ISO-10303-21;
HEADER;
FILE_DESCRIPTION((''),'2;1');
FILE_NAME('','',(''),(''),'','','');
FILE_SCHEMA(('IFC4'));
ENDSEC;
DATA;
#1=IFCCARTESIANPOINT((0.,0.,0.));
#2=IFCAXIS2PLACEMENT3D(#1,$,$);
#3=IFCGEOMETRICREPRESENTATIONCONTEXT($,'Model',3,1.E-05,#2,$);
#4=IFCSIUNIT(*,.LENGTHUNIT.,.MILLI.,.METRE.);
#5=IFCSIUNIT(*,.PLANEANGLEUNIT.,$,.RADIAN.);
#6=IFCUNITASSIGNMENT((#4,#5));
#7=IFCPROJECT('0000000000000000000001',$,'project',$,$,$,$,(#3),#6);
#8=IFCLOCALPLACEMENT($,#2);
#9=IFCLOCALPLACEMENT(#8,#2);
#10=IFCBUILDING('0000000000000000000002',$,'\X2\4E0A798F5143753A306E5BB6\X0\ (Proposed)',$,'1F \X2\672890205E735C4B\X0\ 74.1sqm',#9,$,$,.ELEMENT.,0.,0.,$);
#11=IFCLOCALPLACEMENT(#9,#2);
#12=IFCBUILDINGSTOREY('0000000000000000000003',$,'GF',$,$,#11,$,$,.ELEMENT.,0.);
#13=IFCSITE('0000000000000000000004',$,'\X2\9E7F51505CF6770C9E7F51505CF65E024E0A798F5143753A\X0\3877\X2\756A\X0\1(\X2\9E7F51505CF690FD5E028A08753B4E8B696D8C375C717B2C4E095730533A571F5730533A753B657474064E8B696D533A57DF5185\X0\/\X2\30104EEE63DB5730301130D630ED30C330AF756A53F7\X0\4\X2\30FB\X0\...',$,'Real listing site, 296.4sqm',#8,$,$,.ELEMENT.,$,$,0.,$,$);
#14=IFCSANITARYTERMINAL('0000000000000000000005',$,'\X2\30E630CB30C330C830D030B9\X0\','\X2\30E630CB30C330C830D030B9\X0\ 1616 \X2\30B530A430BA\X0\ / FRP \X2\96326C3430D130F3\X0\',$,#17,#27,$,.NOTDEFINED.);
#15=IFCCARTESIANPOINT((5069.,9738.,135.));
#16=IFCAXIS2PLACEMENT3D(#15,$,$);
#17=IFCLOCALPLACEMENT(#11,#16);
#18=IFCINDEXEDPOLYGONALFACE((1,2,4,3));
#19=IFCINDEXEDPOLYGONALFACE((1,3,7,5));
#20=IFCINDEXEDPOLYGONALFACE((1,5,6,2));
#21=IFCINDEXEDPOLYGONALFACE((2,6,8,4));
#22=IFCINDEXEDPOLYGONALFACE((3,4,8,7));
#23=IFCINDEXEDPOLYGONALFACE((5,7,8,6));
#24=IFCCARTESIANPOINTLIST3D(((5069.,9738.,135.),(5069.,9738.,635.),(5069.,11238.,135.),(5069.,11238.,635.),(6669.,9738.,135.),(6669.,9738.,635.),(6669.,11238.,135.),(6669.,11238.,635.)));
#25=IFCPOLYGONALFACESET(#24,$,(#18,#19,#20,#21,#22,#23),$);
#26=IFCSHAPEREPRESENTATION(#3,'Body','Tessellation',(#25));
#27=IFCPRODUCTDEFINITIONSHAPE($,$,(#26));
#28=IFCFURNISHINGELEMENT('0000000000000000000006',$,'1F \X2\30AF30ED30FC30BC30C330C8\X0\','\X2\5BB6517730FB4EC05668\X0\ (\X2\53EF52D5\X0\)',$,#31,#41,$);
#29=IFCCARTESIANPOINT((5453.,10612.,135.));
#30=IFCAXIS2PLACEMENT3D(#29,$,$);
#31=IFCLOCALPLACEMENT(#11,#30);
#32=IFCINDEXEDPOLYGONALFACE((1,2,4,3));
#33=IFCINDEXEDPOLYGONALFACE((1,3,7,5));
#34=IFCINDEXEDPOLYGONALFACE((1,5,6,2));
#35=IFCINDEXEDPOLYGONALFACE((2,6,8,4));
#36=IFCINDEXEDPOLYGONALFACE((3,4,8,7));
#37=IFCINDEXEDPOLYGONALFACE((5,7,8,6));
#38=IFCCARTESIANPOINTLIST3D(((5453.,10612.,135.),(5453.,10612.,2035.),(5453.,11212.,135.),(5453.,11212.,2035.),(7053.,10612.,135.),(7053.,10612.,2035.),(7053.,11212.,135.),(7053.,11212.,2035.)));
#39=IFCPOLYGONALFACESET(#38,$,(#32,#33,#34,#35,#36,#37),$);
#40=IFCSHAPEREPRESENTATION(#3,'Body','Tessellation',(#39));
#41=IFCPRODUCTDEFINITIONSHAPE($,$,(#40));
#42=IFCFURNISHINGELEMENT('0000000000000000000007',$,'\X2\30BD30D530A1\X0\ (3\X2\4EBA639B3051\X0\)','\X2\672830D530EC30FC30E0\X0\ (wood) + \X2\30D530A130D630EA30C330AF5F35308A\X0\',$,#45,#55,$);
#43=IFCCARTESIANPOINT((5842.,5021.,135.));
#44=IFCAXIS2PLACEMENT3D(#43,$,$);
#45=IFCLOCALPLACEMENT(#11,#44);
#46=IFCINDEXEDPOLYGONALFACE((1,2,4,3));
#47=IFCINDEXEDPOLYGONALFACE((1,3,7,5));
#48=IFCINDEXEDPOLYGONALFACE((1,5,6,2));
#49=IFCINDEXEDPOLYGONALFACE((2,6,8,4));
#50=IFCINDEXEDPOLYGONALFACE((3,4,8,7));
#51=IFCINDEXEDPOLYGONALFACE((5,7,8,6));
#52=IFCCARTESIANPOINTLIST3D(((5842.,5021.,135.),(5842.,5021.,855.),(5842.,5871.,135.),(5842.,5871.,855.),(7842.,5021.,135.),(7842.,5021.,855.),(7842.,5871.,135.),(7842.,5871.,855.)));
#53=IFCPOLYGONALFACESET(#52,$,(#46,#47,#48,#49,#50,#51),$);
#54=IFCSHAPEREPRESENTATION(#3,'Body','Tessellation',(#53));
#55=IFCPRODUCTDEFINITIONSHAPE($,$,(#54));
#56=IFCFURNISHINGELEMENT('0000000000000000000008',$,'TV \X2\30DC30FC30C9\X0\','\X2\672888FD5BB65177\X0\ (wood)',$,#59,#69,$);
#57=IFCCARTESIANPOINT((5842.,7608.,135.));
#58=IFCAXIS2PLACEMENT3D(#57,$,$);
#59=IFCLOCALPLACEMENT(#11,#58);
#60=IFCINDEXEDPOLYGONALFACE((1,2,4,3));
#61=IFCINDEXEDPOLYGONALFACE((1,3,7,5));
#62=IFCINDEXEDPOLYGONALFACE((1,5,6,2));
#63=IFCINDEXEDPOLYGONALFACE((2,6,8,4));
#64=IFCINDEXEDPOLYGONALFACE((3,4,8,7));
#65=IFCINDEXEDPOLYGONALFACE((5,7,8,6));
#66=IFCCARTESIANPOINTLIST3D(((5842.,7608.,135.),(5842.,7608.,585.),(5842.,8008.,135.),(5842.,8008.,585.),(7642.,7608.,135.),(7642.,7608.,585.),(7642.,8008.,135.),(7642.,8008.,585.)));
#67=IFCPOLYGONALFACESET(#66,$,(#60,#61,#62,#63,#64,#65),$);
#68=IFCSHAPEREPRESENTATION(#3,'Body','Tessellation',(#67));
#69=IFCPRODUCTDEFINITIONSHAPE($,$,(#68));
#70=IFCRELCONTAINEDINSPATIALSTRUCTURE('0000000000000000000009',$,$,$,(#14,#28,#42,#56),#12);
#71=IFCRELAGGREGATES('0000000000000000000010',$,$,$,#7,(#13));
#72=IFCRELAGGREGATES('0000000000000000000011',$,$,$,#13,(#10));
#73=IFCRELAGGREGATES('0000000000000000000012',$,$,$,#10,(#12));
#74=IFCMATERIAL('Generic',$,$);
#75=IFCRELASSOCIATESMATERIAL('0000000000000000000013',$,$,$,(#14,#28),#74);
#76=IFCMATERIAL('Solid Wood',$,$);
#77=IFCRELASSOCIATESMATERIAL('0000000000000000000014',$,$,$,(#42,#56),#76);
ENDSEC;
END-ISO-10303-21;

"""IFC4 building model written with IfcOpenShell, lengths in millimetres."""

from ifc_helpers import new_model, si_unit, frame, frame_2d, origin, place, context, project, spatial, rectangle, extrude, material, element, save


model = new_model("IFC4")

# Units and contexts
model_context = context("Model", 3, precision=1e-05, world=origin())
ifc_project = project(units=[si_unit("LENGTHUNIT", "METRE", prefix="MILLI"), si_unit("PLANEANGLEUNIT", "RADIAN")], contexts=[model_context])

# Site, building, storey
site_placement = place(None, origin())
site = spatial("IfcSite", under=ifc_project, at=site_placement, Name="鹿児島県鹿児島市上福元町3877番1(鹿児島都市計画事業谷山第三地区土地区画整理事業区域内/【仮換地】ブロック番号4・...", ObjectType="Real listing site, 296.4sqm", CompositionType="ELEMENT", RefElevation=0.0)
building_placement = place(site_placement, origin())
building = spatial("IfcBuilding", under=site, at=building_placement, Name="上福元町の家 (Proposed)", ObjectType="1F 木造平屋 74.1sqm", CompositionType="ELEMENT", ElevationOfRefHeight=0.0, ElevationOfTerrain=0.0)
storey_placement = place(building_placement, origin())
storey = spatial("IfcBuildingStorey", under=building, at=storey_placement, Name="GF", CompositionType="ELEMENT", Elevation=0.0)

# Shared definitions
ifc_material_1 = material(Name="Solid Wood")

# Shared definitions
ifc_material_2 = material(Name="Generic")

# Sanitary terminal
sanitary_terminal_placement = place(storey_placement, frame((5069.0, 9738.0, 135.0)))
element("IfcSanitaryTerminal", 1, at=sanitary_terminal_placement, inside=storey, material=ifc_material_2, Name="ユニットバス", Description="ユニットバス 1616 サイズ / FRP 防水パン", PredefinedType="NOTDEFINED", context=model_context, shape_type="SweptSolid", body=[
    extrude(rectangle(XDim=1600.0, YDim=1500.0, at=frame_2d((800.0, 750.0))), frame((5069.0, 9738.0, 135.0)), (0.0, 0.0, 1.0), 500.0),
])

# Furnishing elements
furnishing_1_placement = place(storey_placement, frame((5453.0, 10612.0, 135.0)))
element("IfcFurnishingElement", 2, at=furnishing_1_placement, inside=storey, material=ifc_material_2, Name="1F クローゼット", Description="家具・什器 (可動)", context=model_context, shape_type="SweptSolid", body=[
    extrude(rectangle(XDim=1600.0, YDim=600.0, at=frame_2d((800.0, 300.0))), frame((5453.0, 10612.0, 135.0)), (0.0, 0.0, 1.0), 1900.0),
])
furnishing_2_placement = place(storey_placement, frame((5842.0, 5021.0, 135.0)))
element("IfcFurnishingElement", 3, at=furnishing_2_placement, inside=storey, material=ifc_material_1, Name="ソファ (3人掛け)", Description="木フレーム (wood) + ファブリック張り", context=model_context, shape_type="SweptSolid", body=[
    extrude(rectangle(XDim=2000.0, YDim=850.0, at=frame_2d((1000.0, 425.0))), frame((5842.0, 5021.0, 135.0)), (0.0, 0.0, 1.0), 720.0),
])
furnishing_3_placement = place(storey_placement, frame((5842.0, 7608.0, 135.0)))
element("IfcFurnishingElement", 4, at=furnishing_3_placement, inside=storey, material=ifc_material_1, Name="TV ボード", Description="木製家具 (wood)", context=model_context, shape_type="SweptSolid", body=[
    extrude(rectangle(XDim=1800.0, YDim=400.0, at=frame_2d((900.0, 200.0))), frame((5842.0, 7608.0, 135.0)), (0.0, 0.0, 1.0), 450.0),
])

save(model, "model.ifc")
